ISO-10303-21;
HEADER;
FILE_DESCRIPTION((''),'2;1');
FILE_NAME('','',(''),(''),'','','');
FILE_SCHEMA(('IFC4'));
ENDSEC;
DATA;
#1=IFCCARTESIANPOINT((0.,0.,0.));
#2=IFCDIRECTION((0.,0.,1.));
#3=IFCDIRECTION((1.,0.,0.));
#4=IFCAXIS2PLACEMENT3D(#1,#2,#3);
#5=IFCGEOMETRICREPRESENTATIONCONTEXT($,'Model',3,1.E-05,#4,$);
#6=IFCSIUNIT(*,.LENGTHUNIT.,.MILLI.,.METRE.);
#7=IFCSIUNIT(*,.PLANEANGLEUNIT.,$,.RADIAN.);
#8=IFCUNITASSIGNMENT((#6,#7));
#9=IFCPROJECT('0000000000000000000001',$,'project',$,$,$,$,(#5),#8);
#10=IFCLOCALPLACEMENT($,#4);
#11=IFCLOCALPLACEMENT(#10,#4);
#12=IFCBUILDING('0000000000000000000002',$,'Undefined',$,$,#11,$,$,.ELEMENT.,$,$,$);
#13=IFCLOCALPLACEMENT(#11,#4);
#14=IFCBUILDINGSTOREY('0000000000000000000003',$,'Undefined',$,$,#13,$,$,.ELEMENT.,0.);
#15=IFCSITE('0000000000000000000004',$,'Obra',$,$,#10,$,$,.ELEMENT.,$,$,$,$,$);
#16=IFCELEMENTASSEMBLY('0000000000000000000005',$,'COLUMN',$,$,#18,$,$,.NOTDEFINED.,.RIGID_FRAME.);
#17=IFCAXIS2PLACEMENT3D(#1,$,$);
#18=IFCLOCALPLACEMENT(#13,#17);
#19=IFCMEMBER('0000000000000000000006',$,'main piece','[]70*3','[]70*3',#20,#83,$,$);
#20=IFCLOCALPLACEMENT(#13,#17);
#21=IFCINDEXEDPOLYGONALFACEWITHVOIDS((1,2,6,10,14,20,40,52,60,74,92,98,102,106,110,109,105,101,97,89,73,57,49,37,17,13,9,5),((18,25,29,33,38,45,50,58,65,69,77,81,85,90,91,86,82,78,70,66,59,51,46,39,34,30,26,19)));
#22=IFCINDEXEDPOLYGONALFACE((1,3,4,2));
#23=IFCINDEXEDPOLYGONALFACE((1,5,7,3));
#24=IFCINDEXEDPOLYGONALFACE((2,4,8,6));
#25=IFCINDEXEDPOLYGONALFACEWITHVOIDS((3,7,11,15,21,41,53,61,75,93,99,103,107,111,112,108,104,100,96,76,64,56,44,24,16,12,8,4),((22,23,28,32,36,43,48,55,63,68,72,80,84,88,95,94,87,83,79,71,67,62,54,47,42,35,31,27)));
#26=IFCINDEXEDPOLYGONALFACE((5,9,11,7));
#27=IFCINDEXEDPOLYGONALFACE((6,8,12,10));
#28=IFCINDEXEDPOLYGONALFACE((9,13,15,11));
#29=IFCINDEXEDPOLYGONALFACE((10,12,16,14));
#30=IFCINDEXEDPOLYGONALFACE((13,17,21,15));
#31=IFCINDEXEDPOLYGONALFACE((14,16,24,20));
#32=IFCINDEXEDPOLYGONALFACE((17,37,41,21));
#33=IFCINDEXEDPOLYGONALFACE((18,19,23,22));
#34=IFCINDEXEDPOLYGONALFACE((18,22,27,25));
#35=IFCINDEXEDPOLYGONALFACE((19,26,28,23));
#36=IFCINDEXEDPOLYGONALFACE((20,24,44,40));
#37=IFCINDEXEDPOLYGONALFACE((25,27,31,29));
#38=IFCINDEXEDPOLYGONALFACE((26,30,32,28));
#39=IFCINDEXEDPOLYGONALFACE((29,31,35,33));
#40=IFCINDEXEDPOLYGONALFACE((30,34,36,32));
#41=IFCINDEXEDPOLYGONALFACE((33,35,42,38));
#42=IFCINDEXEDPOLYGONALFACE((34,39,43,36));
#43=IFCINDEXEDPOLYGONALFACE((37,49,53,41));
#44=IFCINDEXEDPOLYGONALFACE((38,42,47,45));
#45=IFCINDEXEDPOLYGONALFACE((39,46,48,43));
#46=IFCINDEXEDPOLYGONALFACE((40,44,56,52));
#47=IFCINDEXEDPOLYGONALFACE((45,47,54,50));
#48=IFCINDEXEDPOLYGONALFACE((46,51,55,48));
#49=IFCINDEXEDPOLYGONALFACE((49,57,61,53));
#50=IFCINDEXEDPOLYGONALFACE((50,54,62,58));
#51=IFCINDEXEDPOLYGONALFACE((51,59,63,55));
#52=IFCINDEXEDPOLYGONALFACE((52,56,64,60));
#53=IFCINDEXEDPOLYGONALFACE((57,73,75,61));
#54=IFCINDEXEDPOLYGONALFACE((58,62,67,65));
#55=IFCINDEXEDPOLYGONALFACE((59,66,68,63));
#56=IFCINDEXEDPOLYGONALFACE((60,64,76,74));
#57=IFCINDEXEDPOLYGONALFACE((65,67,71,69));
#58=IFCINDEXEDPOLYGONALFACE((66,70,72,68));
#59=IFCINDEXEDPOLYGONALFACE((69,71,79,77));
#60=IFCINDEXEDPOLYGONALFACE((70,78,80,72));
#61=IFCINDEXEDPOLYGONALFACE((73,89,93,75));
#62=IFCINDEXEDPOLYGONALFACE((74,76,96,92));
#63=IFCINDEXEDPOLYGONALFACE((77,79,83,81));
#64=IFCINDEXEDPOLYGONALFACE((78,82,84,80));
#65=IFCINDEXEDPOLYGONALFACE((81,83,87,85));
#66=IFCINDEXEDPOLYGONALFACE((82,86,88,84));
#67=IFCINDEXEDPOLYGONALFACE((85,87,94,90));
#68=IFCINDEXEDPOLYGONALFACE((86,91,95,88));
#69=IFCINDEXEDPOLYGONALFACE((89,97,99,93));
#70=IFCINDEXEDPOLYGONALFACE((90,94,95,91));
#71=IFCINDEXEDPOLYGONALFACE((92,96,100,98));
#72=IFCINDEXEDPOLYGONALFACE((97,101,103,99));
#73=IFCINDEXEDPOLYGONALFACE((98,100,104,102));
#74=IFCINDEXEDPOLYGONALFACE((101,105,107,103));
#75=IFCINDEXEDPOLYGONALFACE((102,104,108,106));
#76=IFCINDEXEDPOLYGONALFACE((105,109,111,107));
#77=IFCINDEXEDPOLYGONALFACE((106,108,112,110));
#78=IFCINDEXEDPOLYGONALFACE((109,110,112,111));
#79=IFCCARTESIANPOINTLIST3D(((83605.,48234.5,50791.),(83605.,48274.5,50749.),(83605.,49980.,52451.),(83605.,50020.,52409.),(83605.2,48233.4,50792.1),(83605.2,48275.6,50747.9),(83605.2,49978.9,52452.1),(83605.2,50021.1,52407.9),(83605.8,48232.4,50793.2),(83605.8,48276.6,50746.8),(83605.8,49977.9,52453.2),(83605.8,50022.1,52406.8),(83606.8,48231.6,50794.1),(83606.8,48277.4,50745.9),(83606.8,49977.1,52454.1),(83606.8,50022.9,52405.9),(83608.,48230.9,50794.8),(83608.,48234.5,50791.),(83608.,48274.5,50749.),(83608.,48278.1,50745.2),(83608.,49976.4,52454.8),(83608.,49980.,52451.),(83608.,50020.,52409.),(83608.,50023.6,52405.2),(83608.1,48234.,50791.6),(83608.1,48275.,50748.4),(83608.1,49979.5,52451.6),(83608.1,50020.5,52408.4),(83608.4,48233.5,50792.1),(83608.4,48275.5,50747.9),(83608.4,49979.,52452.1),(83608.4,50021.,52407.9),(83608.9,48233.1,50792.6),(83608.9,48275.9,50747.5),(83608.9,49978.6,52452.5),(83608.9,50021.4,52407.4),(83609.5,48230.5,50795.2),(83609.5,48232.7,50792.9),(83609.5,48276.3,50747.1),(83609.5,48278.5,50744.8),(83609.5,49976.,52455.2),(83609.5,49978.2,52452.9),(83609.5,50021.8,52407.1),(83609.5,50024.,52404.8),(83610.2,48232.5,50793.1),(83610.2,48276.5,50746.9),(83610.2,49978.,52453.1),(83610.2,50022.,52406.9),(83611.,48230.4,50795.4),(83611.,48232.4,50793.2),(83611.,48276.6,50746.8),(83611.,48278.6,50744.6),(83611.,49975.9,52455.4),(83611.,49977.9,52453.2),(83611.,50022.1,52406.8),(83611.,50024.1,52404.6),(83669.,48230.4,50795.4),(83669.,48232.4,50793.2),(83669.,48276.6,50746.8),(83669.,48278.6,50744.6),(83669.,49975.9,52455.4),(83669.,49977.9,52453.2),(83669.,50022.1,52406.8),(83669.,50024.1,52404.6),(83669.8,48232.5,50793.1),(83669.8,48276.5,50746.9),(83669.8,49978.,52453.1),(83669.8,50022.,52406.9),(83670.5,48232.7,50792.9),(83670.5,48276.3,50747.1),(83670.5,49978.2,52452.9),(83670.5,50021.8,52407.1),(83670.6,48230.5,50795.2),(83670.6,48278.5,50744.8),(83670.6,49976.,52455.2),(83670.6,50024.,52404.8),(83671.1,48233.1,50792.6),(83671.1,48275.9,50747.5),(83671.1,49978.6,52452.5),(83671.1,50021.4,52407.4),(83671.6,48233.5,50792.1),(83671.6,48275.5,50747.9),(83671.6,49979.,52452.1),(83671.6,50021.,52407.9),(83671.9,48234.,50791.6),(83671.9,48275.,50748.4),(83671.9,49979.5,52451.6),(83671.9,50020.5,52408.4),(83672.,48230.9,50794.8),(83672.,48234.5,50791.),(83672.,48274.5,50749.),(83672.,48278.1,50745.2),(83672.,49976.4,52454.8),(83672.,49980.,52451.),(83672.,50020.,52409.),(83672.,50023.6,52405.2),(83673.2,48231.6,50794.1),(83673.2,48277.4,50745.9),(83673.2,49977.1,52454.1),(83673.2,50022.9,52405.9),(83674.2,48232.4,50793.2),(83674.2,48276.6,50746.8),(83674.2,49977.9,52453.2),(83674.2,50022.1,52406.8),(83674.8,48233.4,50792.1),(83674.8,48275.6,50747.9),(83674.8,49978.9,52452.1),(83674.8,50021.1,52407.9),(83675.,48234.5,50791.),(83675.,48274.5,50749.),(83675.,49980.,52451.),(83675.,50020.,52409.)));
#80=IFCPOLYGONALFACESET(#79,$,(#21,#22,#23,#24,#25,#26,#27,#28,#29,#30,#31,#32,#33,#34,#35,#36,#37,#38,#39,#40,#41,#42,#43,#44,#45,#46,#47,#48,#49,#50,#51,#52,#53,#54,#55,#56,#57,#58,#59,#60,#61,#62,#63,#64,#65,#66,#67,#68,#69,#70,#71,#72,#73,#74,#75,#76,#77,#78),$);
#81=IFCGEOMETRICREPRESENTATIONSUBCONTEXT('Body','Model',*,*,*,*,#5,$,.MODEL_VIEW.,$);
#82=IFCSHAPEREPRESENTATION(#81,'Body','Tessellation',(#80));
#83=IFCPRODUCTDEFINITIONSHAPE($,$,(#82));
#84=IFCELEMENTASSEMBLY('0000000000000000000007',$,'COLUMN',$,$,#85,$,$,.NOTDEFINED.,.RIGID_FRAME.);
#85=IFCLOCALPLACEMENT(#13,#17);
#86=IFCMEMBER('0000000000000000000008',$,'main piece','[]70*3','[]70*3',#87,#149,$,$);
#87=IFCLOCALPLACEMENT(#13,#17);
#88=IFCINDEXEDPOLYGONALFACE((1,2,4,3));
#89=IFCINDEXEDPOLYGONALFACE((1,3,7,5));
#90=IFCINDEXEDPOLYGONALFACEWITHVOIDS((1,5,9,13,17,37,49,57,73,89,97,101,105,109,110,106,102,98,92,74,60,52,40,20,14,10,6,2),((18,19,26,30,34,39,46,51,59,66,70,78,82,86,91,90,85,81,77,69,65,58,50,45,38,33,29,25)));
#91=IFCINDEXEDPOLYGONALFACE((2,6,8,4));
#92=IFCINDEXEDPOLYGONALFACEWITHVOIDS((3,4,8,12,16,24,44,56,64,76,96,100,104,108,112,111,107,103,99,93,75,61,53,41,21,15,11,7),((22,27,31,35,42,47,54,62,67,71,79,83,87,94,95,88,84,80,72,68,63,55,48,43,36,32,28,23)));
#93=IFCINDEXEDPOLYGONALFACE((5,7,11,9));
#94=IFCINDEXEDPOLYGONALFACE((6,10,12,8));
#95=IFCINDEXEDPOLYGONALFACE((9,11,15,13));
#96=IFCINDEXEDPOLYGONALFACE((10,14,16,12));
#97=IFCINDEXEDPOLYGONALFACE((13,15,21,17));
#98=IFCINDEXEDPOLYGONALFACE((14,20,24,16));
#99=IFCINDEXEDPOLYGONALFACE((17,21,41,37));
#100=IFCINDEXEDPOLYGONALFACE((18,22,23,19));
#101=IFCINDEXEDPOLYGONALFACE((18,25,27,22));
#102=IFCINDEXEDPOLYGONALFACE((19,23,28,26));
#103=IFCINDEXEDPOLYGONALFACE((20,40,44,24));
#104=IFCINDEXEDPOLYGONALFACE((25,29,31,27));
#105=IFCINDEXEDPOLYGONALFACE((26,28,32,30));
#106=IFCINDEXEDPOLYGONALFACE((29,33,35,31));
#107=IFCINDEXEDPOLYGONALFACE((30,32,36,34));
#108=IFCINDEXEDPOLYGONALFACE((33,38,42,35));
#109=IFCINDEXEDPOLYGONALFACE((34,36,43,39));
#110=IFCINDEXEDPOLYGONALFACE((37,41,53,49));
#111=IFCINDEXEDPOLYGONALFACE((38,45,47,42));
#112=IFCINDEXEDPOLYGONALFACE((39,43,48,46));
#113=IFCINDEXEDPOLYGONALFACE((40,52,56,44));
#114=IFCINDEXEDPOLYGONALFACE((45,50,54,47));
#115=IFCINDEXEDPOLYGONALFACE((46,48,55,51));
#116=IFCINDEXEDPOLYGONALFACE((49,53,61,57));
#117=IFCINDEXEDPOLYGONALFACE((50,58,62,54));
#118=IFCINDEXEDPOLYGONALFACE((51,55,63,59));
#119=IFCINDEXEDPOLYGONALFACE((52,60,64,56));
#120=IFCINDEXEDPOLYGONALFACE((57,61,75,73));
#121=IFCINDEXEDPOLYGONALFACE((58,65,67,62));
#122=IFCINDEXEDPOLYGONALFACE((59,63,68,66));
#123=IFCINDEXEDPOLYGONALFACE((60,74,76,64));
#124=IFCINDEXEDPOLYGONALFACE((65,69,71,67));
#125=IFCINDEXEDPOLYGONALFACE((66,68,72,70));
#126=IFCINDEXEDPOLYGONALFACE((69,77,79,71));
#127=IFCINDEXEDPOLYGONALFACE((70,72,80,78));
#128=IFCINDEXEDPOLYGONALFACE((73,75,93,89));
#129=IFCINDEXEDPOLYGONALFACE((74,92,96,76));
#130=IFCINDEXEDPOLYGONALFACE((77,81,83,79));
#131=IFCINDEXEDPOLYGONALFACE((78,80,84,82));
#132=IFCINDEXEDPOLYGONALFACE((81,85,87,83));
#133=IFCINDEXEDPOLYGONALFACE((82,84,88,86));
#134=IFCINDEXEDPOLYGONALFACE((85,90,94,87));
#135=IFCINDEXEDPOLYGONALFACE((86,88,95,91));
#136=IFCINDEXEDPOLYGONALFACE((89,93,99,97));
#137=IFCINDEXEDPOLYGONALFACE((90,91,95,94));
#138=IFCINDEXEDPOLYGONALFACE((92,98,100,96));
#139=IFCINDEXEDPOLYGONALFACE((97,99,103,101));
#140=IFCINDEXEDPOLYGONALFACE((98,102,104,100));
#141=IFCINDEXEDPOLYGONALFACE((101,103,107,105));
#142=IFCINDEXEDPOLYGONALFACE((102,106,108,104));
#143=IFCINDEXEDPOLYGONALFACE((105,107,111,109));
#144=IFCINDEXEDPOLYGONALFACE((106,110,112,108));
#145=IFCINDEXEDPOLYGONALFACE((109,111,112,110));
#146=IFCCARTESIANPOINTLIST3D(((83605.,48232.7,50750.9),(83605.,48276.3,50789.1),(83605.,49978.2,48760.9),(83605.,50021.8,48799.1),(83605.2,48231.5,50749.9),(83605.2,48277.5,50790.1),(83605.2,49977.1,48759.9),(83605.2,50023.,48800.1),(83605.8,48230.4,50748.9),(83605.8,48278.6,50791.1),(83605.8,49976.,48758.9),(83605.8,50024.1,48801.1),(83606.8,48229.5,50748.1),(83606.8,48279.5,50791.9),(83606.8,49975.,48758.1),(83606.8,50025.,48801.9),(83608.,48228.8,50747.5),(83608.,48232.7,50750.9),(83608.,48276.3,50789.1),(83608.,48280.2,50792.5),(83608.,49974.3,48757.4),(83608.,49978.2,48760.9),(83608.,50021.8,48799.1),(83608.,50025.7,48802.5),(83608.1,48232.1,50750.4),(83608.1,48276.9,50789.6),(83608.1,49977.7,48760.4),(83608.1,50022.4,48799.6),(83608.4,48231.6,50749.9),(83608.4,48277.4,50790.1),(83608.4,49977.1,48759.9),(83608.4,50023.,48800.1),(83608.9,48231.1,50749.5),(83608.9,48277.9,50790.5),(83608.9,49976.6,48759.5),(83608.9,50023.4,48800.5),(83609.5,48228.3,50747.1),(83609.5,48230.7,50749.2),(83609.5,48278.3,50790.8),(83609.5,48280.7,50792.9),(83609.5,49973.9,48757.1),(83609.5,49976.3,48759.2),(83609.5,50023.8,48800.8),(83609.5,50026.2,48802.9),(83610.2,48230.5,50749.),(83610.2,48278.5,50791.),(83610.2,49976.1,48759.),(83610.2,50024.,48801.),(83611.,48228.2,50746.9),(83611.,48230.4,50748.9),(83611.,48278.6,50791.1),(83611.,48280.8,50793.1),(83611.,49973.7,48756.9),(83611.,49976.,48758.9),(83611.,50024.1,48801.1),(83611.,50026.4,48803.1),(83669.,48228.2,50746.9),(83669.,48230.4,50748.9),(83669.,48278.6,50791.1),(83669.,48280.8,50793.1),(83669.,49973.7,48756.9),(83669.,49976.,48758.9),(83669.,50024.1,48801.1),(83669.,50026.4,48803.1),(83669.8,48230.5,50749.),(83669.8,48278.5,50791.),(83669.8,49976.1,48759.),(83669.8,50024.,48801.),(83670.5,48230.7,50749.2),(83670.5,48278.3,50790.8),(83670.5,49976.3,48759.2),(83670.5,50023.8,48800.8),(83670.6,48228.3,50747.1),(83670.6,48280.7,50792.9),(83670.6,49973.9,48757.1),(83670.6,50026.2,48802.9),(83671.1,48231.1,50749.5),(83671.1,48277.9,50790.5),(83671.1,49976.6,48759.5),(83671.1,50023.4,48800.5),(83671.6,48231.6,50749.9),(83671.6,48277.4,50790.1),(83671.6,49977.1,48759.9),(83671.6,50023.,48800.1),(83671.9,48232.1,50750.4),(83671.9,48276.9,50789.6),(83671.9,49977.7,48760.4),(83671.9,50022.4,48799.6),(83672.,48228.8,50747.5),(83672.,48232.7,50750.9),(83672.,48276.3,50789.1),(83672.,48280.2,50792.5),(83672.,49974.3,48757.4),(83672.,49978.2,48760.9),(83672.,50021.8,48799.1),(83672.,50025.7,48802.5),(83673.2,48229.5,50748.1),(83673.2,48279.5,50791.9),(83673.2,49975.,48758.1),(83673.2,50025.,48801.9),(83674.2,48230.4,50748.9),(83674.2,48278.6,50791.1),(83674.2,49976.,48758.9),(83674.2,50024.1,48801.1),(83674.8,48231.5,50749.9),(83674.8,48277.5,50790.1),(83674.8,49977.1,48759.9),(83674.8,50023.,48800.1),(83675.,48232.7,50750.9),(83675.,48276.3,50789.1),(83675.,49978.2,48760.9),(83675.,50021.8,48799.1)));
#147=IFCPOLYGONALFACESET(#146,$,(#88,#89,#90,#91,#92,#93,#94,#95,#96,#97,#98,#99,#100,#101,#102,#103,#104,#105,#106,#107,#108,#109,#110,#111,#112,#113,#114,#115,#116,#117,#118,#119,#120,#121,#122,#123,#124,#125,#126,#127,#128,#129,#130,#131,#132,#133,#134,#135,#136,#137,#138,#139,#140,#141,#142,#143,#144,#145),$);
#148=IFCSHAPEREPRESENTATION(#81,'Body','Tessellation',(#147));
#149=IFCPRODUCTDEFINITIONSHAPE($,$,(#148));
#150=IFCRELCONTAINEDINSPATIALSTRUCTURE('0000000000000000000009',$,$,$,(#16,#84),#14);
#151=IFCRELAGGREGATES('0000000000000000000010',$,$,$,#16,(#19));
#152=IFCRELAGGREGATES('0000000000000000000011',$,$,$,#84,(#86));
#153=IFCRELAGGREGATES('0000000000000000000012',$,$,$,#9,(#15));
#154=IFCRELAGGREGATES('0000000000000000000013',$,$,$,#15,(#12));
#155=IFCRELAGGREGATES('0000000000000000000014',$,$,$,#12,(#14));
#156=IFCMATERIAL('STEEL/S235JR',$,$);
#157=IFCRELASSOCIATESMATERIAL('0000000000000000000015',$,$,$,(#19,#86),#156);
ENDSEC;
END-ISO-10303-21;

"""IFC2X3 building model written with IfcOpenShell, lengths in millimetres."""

from ifc_helpers import new_model, si_unit, frame, origin_with_axes, origin_2d_with_axis, place, context, subcontext, project, spatial, hollow_rectangle, extrude, material, element, aggregate, save


model = new_model("IFC2X3")

# Units and contexts
model_context = context("Model", 3, precision=1e-05, world=origin_with_axes())
body_context = subcontext(model_context, "Body", "Model", "MODEL_VIEW")
ifc_project = project(units=[si_unit("LENGTHUNIT", "METRE", prefix="MILLI"), si_unit("PLANEANGLEUNIT", "RADIAN")], contexts=[model_context])

# Site, building, storey
site_placement = place(None, origin_with_axes())
site = spatial("IfcSite", under=ifc_project, at=site_placement, Name="Obra", CompositionType="ELEMENT")
building_placement = place(site_placement, origin_with_axes())
building = spatial("IfcBuilding", under=site, at=building_placement, Name="Undefined", CompositionType="ELEMENT")
storey_placement = place(building_placement, origin_with_axes())
storey = spatial("IfcBuildingStorey", under=building, at=storey_placement, Name="Undefined", CompositionType="ELEMENT", Elevation=0.0)

# Shared definitions
ifc_material = material(Name="STEEL/S235JR")

# Element assemblies, members
assembly_1_placement = place(storey_placement, origin_with_axes())
assembly_1 = element("IfcElementAssembly", 1, at=assembly_1_placement, inside=storey, Name="COLUMN", AssemblyPlace="NOTDEFINED", PredefinedType="RIGID_FRAME")
member_1_placement = place(assembly_1_placement, frame((83640.0, 48254.5, 50770.0), z_axis=(-1.0, 0.0, 0.0), x_axis=(0.0, 0.724633, 0.689135)))
member_1 = element("IfcMember", 2, at=member_1_placement, material=ifc_material, Name="main piece", Description="[]70*3", ObjectType="[]70*3", context=body_context, shape_type="SweptSolid", body=[
    extrude(hollow_rectangle(XDim=70.0, YDim=70.0, WallThickness=3.0, InnerFilletRadius=3.0, OuterFilletRadius=6.0, at=origin_2d_with_axis()), frame((2408.8, 0.0, 0.0), z_axis=(-1.0, 0.0, 0.0), x_axis=(0.0, -1.0, 0.0)), (0.0, 0.0, 1.0), 2408.8),
])
aggregate(assembly_1, [member_1])
assembly_2_placement = place(storey_placement, origin_with_axes())
assembly_2 = element("IfcElementAssembly", 3, at=assembly_2_placement, inside=storey, Name="COLUMN", AssemblyPlace="NOTDEFINED", PredefinedType="RIGID_FRAME")
member_2_placement = place(assembly_2_placement, frame((83640.0, 50000.0, 48780.0), z_axis=(1.0, 0.0, 0.0), x_axis=(0.0, -0.659423, 0.751772)))
member_2 = element("IfcMember", 4, at=member_2_placement, material=ifc_material, Name="main piece", Description="[]70*3", ObjectType="[]70*3", context=body_context, shape_type="SweptSolid", body=[
    extrude(hollow_rectangle(XDim=70.0, YDim=70.0, WallThickness=3.0, InnerFilletRadius=3.0, OuterFilletRadius=6.0, at=origin_2d_with_axis()), frame((2647.1, 0.0, 0.0), z_axis=(-1.0, 0.0, 0.0), x_axis=(0.0, -1.0, 0.0)), (0.0, 0.0, 1.0), 2647.1),
])
aggregate(assembly_2, [member_2])

save(model, "model.ifc")
